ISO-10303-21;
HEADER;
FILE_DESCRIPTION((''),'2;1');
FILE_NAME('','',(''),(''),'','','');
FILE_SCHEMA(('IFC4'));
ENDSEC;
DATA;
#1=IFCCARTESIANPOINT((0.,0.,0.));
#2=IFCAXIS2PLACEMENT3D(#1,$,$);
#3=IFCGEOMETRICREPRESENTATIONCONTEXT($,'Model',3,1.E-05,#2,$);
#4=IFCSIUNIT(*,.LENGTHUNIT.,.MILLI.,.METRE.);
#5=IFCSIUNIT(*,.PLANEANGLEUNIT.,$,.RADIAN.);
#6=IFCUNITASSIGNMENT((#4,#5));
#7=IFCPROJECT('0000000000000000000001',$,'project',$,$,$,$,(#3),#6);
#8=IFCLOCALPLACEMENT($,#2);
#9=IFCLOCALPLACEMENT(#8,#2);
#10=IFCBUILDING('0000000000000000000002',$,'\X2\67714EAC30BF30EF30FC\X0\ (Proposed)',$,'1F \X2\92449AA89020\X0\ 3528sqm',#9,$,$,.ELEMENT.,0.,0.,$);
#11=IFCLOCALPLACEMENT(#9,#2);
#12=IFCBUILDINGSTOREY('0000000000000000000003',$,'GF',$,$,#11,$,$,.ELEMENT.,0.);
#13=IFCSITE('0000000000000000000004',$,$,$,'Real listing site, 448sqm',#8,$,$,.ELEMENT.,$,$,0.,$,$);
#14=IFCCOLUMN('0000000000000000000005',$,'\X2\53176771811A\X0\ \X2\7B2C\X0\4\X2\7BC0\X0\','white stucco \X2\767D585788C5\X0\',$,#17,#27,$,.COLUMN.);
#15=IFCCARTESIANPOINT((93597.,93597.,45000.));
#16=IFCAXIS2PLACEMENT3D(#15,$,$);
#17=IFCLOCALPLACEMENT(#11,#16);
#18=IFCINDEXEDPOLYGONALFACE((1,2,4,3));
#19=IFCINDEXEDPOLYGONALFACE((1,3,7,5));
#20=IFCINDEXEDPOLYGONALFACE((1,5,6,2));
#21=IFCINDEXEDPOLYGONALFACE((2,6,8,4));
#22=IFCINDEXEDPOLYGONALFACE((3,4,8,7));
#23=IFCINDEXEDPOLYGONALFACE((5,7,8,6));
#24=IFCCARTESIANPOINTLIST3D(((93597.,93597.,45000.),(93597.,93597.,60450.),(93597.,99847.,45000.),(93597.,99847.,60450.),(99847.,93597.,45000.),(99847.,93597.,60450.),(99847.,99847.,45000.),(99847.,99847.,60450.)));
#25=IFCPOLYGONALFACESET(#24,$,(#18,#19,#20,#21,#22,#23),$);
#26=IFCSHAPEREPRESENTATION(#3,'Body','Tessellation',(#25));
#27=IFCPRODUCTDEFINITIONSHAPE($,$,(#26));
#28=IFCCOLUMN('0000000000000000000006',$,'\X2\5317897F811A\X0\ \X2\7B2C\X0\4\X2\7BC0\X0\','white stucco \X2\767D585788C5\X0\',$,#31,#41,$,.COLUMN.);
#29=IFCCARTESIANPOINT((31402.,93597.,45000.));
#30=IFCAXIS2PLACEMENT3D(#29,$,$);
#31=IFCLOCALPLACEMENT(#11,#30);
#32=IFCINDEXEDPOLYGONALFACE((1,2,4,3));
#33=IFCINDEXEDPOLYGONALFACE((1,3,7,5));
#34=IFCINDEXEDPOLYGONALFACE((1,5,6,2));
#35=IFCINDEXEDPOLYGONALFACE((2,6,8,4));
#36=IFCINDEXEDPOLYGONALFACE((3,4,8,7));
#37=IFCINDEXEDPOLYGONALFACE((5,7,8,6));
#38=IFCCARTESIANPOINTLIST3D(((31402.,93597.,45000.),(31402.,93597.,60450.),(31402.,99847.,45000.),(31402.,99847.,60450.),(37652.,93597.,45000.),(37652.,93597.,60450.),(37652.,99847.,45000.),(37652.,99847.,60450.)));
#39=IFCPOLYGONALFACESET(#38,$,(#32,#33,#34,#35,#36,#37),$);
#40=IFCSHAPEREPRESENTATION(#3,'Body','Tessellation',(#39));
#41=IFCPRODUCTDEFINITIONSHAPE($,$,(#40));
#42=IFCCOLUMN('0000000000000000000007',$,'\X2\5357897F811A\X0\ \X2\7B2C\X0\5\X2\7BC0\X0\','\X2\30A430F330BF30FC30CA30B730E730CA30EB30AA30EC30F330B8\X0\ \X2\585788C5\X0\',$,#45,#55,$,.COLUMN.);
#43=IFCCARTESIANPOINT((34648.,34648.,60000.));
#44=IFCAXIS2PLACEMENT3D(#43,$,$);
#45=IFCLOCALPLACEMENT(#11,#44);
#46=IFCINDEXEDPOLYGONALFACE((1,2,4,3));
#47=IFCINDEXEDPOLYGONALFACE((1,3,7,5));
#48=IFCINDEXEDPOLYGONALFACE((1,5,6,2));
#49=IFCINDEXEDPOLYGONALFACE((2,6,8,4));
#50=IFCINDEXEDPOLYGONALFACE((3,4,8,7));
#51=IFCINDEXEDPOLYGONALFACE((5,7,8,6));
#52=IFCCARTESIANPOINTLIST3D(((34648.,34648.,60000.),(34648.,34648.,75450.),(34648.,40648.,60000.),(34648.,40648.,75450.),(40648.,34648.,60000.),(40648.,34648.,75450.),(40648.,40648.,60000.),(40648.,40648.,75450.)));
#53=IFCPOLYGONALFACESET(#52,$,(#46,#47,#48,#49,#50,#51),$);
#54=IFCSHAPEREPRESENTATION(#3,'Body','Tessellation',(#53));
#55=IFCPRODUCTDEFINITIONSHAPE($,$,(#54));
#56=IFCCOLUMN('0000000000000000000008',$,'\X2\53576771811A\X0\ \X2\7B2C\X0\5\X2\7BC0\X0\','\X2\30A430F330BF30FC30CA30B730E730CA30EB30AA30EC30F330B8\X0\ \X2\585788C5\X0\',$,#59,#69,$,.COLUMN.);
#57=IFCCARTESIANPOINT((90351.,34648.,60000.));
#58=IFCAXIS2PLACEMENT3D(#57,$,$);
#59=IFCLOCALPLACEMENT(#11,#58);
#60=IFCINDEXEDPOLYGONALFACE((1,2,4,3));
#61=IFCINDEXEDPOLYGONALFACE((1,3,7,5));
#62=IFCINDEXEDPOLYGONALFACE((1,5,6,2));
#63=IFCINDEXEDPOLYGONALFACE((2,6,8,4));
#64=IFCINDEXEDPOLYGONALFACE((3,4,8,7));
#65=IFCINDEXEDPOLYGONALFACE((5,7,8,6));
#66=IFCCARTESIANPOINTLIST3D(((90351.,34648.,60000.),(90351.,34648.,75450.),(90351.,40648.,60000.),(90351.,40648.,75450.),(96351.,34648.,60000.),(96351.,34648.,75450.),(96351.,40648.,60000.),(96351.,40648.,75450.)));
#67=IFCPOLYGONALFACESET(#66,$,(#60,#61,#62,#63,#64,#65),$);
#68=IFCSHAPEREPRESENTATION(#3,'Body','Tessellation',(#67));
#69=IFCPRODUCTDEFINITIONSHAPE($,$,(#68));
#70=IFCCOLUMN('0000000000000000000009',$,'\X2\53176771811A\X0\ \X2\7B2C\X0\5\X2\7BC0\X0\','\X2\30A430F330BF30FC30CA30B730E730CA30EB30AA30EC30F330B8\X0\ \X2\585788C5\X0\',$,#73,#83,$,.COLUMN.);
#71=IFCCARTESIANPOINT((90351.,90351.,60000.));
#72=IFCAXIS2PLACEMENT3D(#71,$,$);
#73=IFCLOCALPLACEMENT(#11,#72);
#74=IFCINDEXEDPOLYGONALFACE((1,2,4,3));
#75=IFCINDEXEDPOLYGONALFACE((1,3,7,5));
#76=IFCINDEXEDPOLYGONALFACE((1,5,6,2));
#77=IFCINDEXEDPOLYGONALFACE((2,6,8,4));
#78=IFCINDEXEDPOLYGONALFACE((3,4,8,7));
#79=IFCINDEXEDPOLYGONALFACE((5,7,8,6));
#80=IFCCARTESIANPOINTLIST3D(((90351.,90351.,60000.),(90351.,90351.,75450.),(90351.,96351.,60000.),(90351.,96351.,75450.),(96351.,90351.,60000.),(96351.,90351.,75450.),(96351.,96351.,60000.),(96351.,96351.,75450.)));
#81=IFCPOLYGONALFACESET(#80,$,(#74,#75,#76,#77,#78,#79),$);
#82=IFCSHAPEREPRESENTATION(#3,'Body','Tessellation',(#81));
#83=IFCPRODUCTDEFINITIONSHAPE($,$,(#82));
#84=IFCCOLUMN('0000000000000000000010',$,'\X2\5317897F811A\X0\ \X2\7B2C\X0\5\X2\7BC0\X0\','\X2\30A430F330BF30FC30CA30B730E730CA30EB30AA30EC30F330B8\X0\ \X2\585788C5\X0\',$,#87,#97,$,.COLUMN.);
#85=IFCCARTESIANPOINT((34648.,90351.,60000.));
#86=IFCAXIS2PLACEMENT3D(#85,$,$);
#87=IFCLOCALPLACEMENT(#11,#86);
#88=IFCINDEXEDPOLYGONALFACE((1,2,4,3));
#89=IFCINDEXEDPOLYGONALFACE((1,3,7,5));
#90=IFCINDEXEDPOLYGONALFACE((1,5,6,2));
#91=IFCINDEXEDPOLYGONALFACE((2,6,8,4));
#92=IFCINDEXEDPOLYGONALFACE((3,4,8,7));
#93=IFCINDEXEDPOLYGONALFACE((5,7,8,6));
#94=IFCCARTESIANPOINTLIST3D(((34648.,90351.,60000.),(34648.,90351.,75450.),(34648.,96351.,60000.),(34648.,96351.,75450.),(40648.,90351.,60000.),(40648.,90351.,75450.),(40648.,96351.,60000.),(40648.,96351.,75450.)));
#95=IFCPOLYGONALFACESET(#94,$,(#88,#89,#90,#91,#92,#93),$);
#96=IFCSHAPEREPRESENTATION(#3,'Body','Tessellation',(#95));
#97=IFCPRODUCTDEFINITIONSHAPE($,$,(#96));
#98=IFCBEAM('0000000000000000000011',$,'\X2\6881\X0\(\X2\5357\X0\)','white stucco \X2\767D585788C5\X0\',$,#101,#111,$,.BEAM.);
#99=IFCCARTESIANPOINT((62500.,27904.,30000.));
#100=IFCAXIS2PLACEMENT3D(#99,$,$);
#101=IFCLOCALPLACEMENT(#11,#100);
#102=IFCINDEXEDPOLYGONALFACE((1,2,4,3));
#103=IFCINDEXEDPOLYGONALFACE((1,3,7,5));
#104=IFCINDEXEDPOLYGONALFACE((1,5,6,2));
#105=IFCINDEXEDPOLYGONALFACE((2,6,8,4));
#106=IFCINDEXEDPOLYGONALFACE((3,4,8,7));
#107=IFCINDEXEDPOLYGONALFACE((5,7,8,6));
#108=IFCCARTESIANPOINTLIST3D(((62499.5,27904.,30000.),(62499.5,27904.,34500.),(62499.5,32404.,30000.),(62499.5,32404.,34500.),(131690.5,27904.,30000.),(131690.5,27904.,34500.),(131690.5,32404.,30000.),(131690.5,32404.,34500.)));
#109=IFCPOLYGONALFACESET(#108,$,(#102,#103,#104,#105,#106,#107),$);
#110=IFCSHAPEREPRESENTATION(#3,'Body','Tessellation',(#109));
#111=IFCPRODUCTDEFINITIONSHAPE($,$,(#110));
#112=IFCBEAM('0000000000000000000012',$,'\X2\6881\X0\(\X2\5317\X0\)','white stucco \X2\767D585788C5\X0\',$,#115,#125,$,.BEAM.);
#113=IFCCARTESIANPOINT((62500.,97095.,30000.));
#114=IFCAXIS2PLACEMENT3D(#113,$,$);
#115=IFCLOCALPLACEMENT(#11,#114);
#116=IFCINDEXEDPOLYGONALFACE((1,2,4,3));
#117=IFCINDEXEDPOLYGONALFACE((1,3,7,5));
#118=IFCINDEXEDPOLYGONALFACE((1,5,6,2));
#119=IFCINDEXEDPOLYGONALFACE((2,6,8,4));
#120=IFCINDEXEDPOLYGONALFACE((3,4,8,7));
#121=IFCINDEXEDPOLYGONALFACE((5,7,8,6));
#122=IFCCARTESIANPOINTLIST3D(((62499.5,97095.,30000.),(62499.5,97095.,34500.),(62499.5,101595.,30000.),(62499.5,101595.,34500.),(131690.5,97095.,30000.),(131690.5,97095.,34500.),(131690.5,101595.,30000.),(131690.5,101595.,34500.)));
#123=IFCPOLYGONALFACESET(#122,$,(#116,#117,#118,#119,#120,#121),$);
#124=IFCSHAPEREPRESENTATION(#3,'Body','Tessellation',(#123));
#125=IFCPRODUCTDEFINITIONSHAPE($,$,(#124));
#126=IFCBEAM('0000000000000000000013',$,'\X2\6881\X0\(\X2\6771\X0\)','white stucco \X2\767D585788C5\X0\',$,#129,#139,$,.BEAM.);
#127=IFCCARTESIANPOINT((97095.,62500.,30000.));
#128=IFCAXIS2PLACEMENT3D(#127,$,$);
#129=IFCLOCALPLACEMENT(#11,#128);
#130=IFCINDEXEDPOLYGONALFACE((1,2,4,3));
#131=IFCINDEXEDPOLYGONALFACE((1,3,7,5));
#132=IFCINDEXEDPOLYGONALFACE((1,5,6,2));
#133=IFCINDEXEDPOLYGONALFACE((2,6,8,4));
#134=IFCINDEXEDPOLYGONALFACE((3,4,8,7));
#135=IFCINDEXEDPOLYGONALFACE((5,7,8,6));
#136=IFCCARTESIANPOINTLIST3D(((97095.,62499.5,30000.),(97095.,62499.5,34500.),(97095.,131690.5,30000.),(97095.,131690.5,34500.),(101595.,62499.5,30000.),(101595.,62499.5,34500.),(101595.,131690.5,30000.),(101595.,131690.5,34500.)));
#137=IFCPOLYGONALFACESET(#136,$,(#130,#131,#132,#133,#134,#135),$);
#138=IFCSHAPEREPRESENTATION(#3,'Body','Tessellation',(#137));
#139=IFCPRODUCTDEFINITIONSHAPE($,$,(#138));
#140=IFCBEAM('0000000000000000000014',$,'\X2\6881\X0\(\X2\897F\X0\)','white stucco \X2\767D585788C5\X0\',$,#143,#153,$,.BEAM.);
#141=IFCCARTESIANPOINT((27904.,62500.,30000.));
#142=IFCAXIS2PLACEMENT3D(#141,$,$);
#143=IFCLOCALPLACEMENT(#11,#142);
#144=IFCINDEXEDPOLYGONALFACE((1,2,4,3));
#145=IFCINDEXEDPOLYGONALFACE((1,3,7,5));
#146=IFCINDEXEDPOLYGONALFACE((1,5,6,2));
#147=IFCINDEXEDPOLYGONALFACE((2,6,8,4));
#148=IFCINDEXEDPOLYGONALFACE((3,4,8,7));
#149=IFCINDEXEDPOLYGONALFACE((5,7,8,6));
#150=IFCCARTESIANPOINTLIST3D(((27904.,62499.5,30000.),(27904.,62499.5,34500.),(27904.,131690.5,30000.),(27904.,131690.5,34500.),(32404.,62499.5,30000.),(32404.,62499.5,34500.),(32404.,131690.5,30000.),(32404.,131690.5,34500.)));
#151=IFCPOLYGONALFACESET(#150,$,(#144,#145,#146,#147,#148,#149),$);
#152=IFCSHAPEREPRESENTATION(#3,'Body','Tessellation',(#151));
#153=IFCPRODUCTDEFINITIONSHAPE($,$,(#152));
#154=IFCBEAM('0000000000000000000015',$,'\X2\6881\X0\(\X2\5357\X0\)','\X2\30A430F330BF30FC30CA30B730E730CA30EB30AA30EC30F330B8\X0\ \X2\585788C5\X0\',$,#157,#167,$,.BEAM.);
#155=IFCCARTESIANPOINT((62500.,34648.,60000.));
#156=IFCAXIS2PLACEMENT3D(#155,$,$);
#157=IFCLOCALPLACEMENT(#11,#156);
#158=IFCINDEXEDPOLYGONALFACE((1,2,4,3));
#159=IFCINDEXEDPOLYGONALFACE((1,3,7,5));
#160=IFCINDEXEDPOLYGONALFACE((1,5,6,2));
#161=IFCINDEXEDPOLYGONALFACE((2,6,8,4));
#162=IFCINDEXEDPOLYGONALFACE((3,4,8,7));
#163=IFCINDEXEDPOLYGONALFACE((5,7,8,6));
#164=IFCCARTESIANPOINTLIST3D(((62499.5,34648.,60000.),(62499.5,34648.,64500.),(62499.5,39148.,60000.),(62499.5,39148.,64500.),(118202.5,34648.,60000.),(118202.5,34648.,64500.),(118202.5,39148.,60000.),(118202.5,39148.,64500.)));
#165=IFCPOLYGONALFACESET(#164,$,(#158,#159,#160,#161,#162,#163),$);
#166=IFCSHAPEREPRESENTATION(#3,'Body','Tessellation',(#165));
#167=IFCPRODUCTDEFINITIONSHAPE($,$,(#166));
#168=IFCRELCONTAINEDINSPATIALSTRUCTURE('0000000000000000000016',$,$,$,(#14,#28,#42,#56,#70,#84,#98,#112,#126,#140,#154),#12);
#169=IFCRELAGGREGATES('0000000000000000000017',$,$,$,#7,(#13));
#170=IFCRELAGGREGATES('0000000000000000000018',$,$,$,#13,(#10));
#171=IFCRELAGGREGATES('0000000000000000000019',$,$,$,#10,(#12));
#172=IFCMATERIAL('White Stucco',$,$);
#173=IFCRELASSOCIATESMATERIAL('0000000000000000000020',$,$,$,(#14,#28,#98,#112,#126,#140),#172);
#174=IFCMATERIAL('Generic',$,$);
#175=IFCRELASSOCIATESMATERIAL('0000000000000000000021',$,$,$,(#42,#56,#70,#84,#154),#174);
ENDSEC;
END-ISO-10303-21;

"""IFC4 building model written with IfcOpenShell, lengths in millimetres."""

from ifc_helpers import new_model, si_unit, frame, frame_2d, origin, place, context, project, spatial, rectangle, extrude, material, element, save


model = new_model("IFC4")

# Units and contexts
model_context = context("Model", 3, precision=1e-05, world=origin())
ifc_project = project(units=[si_unit("LENGTHUNIT", "METRE", prefix="MILLI"), si_unit("PLANEANGLEUNIT", "RADIAN")], contexts=[model_context])

# Site, building, storey
site_placement = place(None, origin())
site = spatial("IfcSite", under=ifc_project, at=site_placement, ObjectType="Real listing site, 448sqm", CompositionType="ELEMENT", RefElevation=0.0)
building_placement = place(site_placement, origin())
building = spatial("IfcBuilding", under=site, at=building_placement, Name="東京タワー (Proposed)", ObjectType="1F 鉄骨造 3528sqm", CompositionType="ELEMENT", ElevationOfRefHeight=0.0, ElevationOfTerrain=0.0)
storey_placement = place(building_placement, origin())
storey = spatial("IfcBuildingStorey", under=building, at=storey_placement, Name="GF", CompositionType="ELEMENT", Elevation=0.0)

# Columns
ifc_material_1 = material(Name="Generic")
ifc_material_2 = material(Name="White Stucco")
column_1_placement = place(storey_placement, frame((93597.0, 93597.0, 45000.0)))
element("IfcColumn", 1, at=column_1_placement, inside=storey, material=ifc_material_2, Name="北東脚 第4節", Description="white stucco 白塗装", PredefinedType="COLUMN", context=model_context, shape_type="SweptSolid", body=[
    extrude(rectangle(XDim=6250.0, YDim=6250.0, at=frame_2d((3125.0, 3125.0))), frame((93597.0, 93597.0, 45000.0)), (0.0, 0.0, 1.0), 15450.0),
])
column_2_placement = place(storey_placement, frame((31402.0, 93597.0, 45000.0)))
element("IfcColumn", 2, at=column_2_placement, inside=storey, material=ifc_material_2, Name="北西脚 第4節", Description="white stucco 白塗装", PredefinedType="COLUMN", context=model_context, shape_type="SweptSolid", body=[
    extrude(rectangle(XDim=6250.0, YDim=6250.0, at=frame_2d((3125.0, 3125.0))), frame((31402.0, 93597.0, 45000.0)), (0.0, 0.0, 1.0), 15450.0),
])
column_3_placement = place(storey_placement, frame((34648.0, 34648.0, 60000.0)))
element("IfcColumn", 3, at=column_3_placement, inside=storey, material=ifc_material_1, Name="南西脚 第5節", Description="インターナショナルオレンジ 塗装", PredefinedType="COLUMN", context=model_context, shape_type="SweptSolid", body=[
    extrude(rectangle(XDim=6000.0, YDim=6000.0, at=frame_2d((3000.0, 3000.0))), frame((34648.0, 34648.0, 60000.0)), (0.0, 0.0, 1.0), 15450.0),
])
column_4_placement = place(storey_placement, frame((90351.0, 34648.0, 60000.0)))
element("IfcColumn", 4, at=column_4_placement, inside=storey, material=ifc_material_1, Name="南東脚 第5節", Description="インターナショナルオレンジ 塗装", PredefinedType="COLUMN", context=model_context, shape_type="SweptSolid", body=[
    extrude(rectangle(XDim=6000.0, YDim=6000.0, at=frame_2d((3000.0, 3000.0))), frame((90351.0, 34648.0, 60000.0)), (0.0, 0.0, 1.0), 15450.0),
])
column_5_placement = place(storey_placement, frame((90351.0, 90351.0, 60000.0)))
element("IfcColumn", 5, at=column_5_placement, inside=storey, material=ifc_material_1, Name="北東脚 第5節", Description="インターナショナルオレンジ 塗装", PredefinedType="COLUMN", context=model_context, shape_type="SweptSolid", body=[
    extrude(rectangle(XDim=6000.0, YDim=6000.0, at=frame_2d((3000.0, 3000.0))), frame((90351.0, 90351.0, 60000.0)), (0.0, 0.0, 1.0), 15450.0),
])
column_6_placement = place(storey_placement, frame((34648.0, 90351.0, 60000.0)))
element("IfcColumn", 6, at=column_6_placement, inside=storey, material=ifc_material_1, Name="北西脚 第5節", Description="インターナショナルオレンジ 塗装", PredefinedType="COLUMN", context=model_context, shape_type="SweptSolid", body=[
    extrude(rectangle(XDim=6000.0, YDim=6000.0, at=frame_2d((3000.0, 3000.0))), frame((34648.0, 90351.0, 60000.0)), (0.0, 0.0, 1.0), 15450.0),
])

# Beams
beam_1_placement = place(storey_placement, frame((62500.0, 27904.0, 30000.0)))
element("IfcBeam", 7, at=beam_1_placement, inside=storey, material=ifc_material_2, Name="梁(南)", Description="white stucco 白塗装", PredefinedType="BEAM", context=model_context, shape_type="SweptSolid", body=[
    extrude(rectangle(XDim=69191.0, YDim=4500.0, at=frame_2d((34595.0, 2250.0))), frame((62500.0, 27904.0, 30000.0)), (0.0, 0.0, 1.0), 4500.0),
])
beam_2_placement = place(storey_placement, frame((62500.0, 97095.0, 30000.0)))
element("IfcBeam", 8, at=beam_2_placement, inside=storey, material=ifc_material_2, Name="梁(北)", Description="white stucco 白塗装", PredefinedType="BEAM", context=model_context, shape_type="SweptSolid", body=[
    extrude(rectangle(XDim=69191.0, YDim=4500.0, at=frame_2d((34595.0, 2250.0))), frame((62500.0, 97095.0, 30000.0)), (0.0, 0.0, 1.0), 4500.0),
])
beam_3_placement = place(storey_placement, frame((97095.0, 62500.0, 30000.0)))
element("IfcBeam", 9, at=beam_3_placement, inside=storey, material=ifc_material_2, Name="梁(東)", Description="white stucco 白塗装", PredefinedType="BEAM", context=model_context, shape_type="SweptSolid", body=[
    extrude(rectangle(XDim=4500.0, YDim=69191.0, at=frame_2d((2250.0, 34595.0))), frame((97095.0, 62500.0, 30000.0)), (0.0, 0.0, 1.0), 4500.0),
])
beam_4_placement = place(storey_placement, frame((27904.0, 62500.0, 30000.0)))
element("IfcBeam", 10, at=beam_4_placement, inside=storey, material=ifc_material_2, Name="梁(西)", Description="white stucco 白塗装", PredefinedType="BEAM", context=model_context, shape_type="SweptSolid", body=[
    extrude(rectangle(XDim=4500.0, YDim=69191.0, at=frame_2d((2250.0, 34595.0))), frame((27904.0, 62500.0, 30000.0)), (0.0, 0.0, 1.0), 4500.0),
])
beam_5_placement = place(storey_placement, frame((62500.0, 34648.0, 60000.0)))
element("IfcBeam", 11, at=beam_5_placement, inside=storey, material=ifc_material_1, Name="梁(南)", Description="インターナショナルオレンジ 塗装", PredefinedType="BEAM", context=model_context, shape_type="SweptSolid", body=[
    extrude(rectangle(XDim=55703.0, YDim=4500.0, at=frame_2d((27851.0, 2250.0))), frame((62500.0, 34648.0, 60000.0)), (0.0, 0.0, 1.0), 4500.0),
])

save(model, "model.ifc")
